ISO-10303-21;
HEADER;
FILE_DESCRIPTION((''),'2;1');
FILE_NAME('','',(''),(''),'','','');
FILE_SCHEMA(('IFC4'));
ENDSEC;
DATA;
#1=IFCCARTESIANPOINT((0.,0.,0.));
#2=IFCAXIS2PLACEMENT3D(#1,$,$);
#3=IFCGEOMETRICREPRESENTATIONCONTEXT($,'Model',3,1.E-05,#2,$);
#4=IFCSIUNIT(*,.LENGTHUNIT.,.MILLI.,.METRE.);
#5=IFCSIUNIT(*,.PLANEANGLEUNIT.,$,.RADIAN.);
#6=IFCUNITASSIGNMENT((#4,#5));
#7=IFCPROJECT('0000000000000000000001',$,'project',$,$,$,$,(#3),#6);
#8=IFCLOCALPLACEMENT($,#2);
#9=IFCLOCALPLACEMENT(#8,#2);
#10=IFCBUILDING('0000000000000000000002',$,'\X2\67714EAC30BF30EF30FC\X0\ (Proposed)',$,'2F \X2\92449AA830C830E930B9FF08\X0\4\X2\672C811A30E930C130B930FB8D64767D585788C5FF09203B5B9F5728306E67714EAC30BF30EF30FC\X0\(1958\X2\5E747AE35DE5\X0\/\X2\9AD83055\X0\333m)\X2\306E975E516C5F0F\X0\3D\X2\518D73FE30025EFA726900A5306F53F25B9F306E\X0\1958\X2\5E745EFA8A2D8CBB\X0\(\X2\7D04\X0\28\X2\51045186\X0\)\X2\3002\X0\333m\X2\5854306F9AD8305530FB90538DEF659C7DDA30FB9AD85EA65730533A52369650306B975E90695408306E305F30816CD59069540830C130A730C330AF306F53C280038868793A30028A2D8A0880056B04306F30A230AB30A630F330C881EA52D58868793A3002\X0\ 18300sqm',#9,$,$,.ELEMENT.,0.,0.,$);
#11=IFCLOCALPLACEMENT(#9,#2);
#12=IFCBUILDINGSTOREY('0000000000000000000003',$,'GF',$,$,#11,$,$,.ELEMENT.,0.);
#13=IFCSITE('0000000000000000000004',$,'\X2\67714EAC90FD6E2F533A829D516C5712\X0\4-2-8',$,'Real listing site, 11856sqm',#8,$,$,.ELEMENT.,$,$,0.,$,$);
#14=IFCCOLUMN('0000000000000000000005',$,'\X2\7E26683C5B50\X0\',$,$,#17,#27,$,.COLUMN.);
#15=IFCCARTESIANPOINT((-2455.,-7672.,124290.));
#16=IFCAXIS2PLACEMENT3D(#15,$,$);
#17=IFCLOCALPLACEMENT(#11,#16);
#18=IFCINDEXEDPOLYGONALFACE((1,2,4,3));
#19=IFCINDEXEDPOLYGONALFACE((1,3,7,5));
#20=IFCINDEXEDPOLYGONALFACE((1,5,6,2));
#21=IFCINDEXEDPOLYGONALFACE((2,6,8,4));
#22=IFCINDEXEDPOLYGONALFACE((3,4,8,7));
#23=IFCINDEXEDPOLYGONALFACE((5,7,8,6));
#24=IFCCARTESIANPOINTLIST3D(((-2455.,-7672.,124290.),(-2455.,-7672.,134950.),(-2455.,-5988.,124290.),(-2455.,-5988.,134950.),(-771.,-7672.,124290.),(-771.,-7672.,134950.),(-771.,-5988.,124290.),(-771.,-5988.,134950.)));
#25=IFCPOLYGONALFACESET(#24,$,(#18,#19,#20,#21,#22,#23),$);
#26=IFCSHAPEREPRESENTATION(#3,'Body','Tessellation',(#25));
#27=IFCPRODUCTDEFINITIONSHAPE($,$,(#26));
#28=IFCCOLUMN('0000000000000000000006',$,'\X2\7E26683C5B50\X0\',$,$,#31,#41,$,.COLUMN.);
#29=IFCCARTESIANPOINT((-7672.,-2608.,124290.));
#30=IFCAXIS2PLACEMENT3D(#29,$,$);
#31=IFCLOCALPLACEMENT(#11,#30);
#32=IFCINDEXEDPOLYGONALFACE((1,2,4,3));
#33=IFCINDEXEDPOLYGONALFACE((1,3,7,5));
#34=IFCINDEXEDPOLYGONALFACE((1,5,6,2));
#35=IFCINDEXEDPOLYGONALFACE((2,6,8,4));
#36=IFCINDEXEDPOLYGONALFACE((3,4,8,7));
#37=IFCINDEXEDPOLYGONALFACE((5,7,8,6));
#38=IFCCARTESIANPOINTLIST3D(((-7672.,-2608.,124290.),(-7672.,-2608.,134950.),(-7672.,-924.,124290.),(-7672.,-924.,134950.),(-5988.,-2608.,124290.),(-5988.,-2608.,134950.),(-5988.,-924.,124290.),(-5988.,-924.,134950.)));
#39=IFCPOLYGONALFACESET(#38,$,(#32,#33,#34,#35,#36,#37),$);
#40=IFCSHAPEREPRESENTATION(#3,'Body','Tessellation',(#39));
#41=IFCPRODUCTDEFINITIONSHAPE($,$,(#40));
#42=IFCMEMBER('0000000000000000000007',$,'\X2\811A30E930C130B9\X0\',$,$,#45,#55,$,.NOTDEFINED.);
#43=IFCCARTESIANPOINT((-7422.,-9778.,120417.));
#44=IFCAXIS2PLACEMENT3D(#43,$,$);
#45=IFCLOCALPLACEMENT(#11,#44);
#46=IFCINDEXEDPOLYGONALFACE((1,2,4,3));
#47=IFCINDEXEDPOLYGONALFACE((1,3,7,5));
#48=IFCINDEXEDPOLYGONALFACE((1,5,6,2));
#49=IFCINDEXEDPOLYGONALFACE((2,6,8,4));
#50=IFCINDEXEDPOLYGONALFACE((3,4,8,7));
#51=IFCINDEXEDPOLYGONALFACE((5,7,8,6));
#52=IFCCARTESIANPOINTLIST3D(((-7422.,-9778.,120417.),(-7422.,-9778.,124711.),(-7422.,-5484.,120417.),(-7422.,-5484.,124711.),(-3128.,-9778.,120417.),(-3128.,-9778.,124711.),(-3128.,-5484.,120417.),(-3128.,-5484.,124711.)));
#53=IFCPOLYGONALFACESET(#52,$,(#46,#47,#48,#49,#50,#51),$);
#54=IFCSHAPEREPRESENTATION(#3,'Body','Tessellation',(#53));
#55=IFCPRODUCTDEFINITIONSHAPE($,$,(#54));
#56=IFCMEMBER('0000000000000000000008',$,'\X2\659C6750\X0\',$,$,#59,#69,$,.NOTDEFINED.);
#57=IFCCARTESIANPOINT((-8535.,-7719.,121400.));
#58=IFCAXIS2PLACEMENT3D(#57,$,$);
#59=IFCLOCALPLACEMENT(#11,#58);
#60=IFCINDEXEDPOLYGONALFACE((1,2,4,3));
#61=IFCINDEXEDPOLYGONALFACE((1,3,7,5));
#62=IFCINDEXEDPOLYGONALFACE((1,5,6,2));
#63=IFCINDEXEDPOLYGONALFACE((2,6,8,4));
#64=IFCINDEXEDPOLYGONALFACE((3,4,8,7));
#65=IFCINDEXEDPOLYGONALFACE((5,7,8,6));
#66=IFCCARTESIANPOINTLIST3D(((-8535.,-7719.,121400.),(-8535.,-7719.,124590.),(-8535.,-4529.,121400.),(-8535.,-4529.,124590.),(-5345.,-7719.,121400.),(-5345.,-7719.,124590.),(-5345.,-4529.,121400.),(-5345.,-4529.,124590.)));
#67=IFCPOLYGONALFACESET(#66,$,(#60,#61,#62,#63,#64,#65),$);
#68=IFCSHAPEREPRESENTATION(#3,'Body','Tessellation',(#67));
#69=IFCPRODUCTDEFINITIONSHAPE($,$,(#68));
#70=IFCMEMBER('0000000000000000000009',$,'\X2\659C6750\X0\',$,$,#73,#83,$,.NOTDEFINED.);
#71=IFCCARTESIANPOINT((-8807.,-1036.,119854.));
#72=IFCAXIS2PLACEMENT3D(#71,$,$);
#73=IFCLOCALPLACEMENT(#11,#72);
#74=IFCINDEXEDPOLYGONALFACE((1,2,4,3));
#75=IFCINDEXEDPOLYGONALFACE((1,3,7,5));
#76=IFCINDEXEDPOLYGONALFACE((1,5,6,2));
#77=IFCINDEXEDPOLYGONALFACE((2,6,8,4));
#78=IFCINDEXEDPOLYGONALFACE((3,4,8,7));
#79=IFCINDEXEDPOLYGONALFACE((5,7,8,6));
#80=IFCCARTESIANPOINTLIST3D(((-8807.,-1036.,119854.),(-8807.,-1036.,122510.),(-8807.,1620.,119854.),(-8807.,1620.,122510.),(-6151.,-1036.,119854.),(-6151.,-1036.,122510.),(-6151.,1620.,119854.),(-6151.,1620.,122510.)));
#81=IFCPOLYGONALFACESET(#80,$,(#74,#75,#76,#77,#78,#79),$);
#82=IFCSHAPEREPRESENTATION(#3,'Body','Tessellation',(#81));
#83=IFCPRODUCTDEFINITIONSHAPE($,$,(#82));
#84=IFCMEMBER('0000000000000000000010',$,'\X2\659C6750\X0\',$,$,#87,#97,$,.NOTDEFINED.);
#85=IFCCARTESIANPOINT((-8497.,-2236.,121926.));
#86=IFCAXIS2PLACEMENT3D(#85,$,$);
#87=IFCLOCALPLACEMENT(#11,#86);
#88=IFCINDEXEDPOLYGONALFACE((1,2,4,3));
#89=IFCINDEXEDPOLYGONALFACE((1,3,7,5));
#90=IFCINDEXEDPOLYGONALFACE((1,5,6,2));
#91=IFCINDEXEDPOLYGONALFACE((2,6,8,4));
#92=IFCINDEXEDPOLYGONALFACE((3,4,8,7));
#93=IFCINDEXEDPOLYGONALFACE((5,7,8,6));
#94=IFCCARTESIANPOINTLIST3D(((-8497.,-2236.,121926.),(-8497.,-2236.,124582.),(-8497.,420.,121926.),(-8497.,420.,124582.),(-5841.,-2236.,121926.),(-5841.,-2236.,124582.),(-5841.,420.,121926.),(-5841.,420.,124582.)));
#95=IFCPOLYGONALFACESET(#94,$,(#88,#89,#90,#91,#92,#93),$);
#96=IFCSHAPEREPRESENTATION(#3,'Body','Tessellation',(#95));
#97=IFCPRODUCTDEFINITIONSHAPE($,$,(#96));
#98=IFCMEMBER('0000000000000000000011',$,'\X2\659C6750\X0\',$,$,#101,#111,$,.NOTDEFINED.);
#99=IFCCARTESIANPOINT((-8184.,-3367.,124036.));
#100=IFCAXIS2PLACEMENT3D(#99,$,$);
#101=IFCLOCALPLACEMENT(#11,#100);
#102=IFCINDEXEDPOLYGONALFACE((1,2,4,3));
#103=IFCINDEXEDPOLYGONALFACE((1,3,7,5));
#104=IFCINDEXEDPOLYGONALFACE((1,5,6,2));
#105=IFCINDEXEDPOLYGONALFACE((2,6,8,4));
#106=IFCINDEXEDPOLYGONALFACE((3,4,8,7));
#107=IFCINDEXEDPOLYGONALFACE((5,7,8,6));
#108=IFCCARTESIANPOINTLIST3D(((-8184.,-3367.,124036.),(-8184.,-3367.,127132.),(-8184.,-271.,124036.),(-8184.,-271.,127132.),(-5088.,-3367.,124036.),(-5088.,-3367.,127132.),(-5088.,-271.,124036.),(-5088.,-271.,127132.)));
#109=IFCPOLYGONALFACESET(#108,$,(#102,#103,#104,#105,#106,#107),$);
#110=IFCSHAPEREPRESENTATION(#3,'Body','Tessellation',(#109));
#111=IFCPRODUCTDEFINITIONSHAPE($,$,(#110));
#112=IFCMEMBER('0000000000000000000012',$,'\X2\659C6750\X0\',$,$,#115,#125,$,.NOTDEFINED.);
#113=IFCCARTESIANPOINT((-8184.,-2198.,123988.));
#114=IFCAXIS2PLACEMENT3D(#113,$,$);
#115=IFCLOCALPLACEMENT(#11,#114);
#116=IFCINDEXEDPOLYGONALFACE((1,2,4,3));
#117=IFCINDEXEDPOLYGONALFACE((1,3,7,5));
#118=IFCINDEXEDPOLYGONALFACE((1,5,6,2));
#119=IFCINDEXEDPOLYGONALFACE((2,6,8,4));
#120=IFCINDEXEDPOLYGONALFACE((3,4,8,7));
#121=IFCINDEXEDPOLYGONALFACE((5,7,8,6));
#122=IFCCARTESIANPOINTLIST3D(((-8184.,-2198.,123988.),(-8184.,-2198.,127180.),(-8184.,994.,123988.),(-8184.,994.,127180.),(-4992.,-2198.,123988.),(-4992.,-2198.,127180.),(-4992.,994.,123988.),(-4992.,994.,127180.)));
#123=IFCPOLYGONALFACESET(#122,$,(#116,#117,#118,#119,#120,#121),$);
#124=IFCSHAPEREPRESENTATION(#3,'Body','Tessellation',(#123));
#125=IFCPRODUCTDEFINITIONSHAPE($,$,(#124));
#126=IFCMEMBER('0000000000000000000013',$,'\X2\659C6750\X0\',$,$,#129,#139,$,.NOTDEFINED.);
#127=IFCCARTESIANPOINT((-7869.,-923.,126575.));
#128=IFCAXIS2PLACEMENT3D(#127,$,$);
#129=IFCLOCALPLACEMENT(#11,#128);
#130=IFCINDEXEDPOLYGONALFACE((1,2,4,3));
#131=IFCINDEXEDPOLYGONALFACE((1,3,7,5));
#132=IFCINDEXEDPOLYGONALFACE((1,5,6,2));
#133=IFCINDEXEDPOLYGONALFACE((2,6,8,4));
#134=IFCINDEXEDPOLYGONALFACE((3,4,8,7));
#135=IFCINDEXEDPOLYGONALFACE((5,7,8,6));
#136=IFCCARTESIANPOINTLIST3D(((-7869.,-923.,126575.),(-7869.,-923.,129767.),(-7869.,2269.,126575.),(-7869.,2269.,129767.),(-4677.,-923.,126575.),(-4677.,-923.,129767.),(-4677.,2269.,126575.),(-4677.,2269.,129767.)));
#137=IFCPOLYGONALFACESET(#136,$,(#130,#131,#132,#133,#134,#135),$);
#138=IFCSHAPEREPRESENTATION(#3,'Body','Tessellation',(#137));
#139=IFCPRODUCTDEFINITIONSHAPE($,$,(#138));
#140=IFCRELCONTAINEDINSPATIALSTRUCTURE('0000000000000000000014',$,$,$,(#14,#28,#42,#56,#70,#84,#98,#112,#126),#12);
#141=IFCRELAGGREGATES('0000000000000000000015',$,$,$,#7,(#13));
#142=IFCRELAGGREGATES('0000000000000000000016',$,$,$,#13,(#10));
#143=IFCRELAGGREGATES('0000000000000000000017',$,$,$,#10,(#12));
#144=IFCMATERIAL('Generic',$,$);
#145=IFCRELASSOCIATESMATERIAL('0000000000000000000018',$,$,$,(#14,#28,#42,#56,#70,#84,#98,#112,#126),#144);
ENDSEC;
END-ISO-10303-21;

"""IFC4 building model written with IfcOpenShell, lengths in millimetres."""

from ifc_helpers import new_model, si_unit, frame, frame_2d, origin, place, context, project, spatial, rectangle, extrude, material, element, save


model = new_model("IFC4")

# Units and contexts
model_context = context("Model", 3, precision=1e-05, world=origin())
ifc_project = project(units=[si_unit("LENGTHUNIT", "METRE", prefix="MILLI"), si_unit("PLANEANGLEUNIT", "RADIAN")], contexts=[model_context])

# Site, building, storey
site_placement = place(None, origin())
site = spatial("IfcSite", under=ifc_project, at=site_placement, Name="東京都港区芝公園4-2-8", ObjectType="Real listing site, 11856sqm", CompositionType="ELEMENT", RefElevation=0.0)
building_placement = place(site_placement, origin())
building = spatial("IfcBuilding", under=site, at=building_placement, Name="東京タワー (Proposed)", ObjectType="2F 鉄骨トラス（4本脚ラチス・赤白塗装）※実在の東京タワー(1958年竣工/高さ333m)の非公式3D再現。建物¥は史実の1958年建設費(約28億円)。333m塔は高さ・道路斜線・高度地区制限に非適合のため法適合チェックは参考表示。設計者欄はアカウント自動表示。 18300sqm", CompositionType="ELEMENT", ElevationOfRefHeight=0.0, ElevationOfTerrain=0.0)
storey_placement = place(building_placement, origin())
storey = spatial("IfcBuildingStorey", under=building, at=storey_placement, Name="GF", CompositionType="ELEMENT", Elevation=0.0)

# Columns
ifc_material = material(Name="Generic")
column_1_placement = place(storey_placement, frame((-2455.0, -7672.0, 124290.0)))
element("IfcColumn", 1, at=column_1_placement, inside=storey, material=ifc_material, Name="縦格子", PredefinedType="COLUMN", context=model_context, shape_type="SweptSolid", body=[
    extrude(rectangle(XDim=1684.0, YDim=1684.0, at=frame_2d((842.0, 842.0))), frame((-2455.0, -7672.0, 124290.0)), (0.0, 0.0, 1.0), 10660.0),
])
column_2_placement = place(storey_placement, frame((-7672.0, -2608.0, 124290.0)))
element("IfcColumn", 2, at=column_2_placement, inside=storey, material=ifc_material, Name="縦格子", PredefinedType="COLUMN", context=model_context, shape_type="SweptSolid", body=[
    extrude(rectangle(XDim=1684.0, YDim=1684.0, at=frame_2d((842.0, 842.0))), frame((-7672.0, -2608.0, 124290.0)), (0.0, 0.0, 1.0), 10660.0),
])

# Members
member_1_placement = place(storey_placement, frame((-7422.0, -9778.0, 120417.0)))
element("IfcMember", 3, at=member_1_placement, inside=storey, material=ifc_material, Name="脚ラチス", PredefinedType="NOTDEFINED", context=model_context, shape_type="SweptSolid", body=[
    extrude(rectangle(XDim=4294.0, YDim=4294.0, at=frame_2d((2147.0, 2147.0))), frame((-7422.0, -9778.0, 120417.0)), (0.0, 0.0, 1.0), 4294.0),
])
member_2_placement = place(storey_placement, frame((-8535.0, -7719.0, 121400.0)))
element("IfcMember", 4, at=member_2_placement, inside=storey, material=ifc_material, Name="斜材", PredefinedType="NOTDEFINED", context=model_context, shape_type="SweptSolid", body=[
    extrude(rectangle(XDim=3190.0, YDim=3190.0, at=frame_2d((1595.0, 1595.0))), frame((-8535.0, -7719.0, 121400.0)), (0.0, 0.0, 1.0), 3190.0),
])
member_3_placement = place(storey_placement, frame((-8807.0, -1036.0, 119854.0)))
element("IfcMember", 5, at=member_3_placement, inside=storey, material=ifc_material, Name="斜材", PredefinedType="NOTDEFINED", context=model_context, shape_type="SweptSolid", body=[
    extrude(rectangle(XDim=2656.0, YDim=2656.0, at=frame_2d((1328.0, 1328.0))), frame((-8807.0, -1036.0, 119854.0)), (0.0, 0.0, 1.0), 2656.0),
])
member_4_placement = place(storey_placement, frame((-8497.0, -2236.0, 121926.0)))
element("IfcMember", 6, at=member_4_placement, inside=storey, material=ifc_material, Name="斜材", PredefinedType="NOTDEFINED", context=model_context, shape_type="SweptSolid", body=[
    extrude(rectangle(XDim=2656.0, YDim=2656.0, at=frame_2d((1328.0, 1328.0))), frame((-8497.0, -2236.0, 121926.0)), (0.0, 0.0, 1.0), 2656.0),
])
member_5_placement = place(storey_placement, frame((-8184.0, -3367.0, 124036.0)))
element("IfcMember", 7, at=member_5_placement, inside=storey, material=ifc_material, Name="斜材", PredefinedType="NOTDEFINED", context=model_context, shape_type="SweptSolid", body=[
    extrude(rectangle(XDim=3096.0, YDim=3096.0, at=frame_2d((1548.0, 1548.0))), frame((-8184.0, -3367.0, 124036.0)), (0.0, 0.0, 1.0), 3096.0),
])
member_6_placement = place(storey_placement, frame((-8184.0, -2198.0, 123988.0)))
element("IfcMember", 8, at=member_6_placement, inside=storey, material=ifc_material, Name="斜材", PredefinedType="NOTDEFINED", context=model_context, shape_type="SweptSolid", body=[
    extrude(rectangle(XDim=3192.0, YDim=3192.0, at=frame_2d((1596.0, 1596.0))), frame((-8184.0, -2198.0, 123988.0)), (0.0, 0.0, 1.0), 3192.0),
])
member_7_placement = place(storey_placement, frame((-7869.0, -923.0, 126575.0)))
element("IfcMember", 9, at=member_7_placement, inside=storey, material=ifc_material, Name="斜材", PredefinedType="NOTDEFINED", context=model_context, shape_type="SweptSolid", body=[
    extrude(rectangle(XDim=3192.0, YDim=3192.0, at=frame_2d((1596.0, 1596.0))), frame((-7869.0, -923.0, 126575.0)), (0.0, 0.0, 1.0), 3192.0),
])

save(model, "model.ifc")
